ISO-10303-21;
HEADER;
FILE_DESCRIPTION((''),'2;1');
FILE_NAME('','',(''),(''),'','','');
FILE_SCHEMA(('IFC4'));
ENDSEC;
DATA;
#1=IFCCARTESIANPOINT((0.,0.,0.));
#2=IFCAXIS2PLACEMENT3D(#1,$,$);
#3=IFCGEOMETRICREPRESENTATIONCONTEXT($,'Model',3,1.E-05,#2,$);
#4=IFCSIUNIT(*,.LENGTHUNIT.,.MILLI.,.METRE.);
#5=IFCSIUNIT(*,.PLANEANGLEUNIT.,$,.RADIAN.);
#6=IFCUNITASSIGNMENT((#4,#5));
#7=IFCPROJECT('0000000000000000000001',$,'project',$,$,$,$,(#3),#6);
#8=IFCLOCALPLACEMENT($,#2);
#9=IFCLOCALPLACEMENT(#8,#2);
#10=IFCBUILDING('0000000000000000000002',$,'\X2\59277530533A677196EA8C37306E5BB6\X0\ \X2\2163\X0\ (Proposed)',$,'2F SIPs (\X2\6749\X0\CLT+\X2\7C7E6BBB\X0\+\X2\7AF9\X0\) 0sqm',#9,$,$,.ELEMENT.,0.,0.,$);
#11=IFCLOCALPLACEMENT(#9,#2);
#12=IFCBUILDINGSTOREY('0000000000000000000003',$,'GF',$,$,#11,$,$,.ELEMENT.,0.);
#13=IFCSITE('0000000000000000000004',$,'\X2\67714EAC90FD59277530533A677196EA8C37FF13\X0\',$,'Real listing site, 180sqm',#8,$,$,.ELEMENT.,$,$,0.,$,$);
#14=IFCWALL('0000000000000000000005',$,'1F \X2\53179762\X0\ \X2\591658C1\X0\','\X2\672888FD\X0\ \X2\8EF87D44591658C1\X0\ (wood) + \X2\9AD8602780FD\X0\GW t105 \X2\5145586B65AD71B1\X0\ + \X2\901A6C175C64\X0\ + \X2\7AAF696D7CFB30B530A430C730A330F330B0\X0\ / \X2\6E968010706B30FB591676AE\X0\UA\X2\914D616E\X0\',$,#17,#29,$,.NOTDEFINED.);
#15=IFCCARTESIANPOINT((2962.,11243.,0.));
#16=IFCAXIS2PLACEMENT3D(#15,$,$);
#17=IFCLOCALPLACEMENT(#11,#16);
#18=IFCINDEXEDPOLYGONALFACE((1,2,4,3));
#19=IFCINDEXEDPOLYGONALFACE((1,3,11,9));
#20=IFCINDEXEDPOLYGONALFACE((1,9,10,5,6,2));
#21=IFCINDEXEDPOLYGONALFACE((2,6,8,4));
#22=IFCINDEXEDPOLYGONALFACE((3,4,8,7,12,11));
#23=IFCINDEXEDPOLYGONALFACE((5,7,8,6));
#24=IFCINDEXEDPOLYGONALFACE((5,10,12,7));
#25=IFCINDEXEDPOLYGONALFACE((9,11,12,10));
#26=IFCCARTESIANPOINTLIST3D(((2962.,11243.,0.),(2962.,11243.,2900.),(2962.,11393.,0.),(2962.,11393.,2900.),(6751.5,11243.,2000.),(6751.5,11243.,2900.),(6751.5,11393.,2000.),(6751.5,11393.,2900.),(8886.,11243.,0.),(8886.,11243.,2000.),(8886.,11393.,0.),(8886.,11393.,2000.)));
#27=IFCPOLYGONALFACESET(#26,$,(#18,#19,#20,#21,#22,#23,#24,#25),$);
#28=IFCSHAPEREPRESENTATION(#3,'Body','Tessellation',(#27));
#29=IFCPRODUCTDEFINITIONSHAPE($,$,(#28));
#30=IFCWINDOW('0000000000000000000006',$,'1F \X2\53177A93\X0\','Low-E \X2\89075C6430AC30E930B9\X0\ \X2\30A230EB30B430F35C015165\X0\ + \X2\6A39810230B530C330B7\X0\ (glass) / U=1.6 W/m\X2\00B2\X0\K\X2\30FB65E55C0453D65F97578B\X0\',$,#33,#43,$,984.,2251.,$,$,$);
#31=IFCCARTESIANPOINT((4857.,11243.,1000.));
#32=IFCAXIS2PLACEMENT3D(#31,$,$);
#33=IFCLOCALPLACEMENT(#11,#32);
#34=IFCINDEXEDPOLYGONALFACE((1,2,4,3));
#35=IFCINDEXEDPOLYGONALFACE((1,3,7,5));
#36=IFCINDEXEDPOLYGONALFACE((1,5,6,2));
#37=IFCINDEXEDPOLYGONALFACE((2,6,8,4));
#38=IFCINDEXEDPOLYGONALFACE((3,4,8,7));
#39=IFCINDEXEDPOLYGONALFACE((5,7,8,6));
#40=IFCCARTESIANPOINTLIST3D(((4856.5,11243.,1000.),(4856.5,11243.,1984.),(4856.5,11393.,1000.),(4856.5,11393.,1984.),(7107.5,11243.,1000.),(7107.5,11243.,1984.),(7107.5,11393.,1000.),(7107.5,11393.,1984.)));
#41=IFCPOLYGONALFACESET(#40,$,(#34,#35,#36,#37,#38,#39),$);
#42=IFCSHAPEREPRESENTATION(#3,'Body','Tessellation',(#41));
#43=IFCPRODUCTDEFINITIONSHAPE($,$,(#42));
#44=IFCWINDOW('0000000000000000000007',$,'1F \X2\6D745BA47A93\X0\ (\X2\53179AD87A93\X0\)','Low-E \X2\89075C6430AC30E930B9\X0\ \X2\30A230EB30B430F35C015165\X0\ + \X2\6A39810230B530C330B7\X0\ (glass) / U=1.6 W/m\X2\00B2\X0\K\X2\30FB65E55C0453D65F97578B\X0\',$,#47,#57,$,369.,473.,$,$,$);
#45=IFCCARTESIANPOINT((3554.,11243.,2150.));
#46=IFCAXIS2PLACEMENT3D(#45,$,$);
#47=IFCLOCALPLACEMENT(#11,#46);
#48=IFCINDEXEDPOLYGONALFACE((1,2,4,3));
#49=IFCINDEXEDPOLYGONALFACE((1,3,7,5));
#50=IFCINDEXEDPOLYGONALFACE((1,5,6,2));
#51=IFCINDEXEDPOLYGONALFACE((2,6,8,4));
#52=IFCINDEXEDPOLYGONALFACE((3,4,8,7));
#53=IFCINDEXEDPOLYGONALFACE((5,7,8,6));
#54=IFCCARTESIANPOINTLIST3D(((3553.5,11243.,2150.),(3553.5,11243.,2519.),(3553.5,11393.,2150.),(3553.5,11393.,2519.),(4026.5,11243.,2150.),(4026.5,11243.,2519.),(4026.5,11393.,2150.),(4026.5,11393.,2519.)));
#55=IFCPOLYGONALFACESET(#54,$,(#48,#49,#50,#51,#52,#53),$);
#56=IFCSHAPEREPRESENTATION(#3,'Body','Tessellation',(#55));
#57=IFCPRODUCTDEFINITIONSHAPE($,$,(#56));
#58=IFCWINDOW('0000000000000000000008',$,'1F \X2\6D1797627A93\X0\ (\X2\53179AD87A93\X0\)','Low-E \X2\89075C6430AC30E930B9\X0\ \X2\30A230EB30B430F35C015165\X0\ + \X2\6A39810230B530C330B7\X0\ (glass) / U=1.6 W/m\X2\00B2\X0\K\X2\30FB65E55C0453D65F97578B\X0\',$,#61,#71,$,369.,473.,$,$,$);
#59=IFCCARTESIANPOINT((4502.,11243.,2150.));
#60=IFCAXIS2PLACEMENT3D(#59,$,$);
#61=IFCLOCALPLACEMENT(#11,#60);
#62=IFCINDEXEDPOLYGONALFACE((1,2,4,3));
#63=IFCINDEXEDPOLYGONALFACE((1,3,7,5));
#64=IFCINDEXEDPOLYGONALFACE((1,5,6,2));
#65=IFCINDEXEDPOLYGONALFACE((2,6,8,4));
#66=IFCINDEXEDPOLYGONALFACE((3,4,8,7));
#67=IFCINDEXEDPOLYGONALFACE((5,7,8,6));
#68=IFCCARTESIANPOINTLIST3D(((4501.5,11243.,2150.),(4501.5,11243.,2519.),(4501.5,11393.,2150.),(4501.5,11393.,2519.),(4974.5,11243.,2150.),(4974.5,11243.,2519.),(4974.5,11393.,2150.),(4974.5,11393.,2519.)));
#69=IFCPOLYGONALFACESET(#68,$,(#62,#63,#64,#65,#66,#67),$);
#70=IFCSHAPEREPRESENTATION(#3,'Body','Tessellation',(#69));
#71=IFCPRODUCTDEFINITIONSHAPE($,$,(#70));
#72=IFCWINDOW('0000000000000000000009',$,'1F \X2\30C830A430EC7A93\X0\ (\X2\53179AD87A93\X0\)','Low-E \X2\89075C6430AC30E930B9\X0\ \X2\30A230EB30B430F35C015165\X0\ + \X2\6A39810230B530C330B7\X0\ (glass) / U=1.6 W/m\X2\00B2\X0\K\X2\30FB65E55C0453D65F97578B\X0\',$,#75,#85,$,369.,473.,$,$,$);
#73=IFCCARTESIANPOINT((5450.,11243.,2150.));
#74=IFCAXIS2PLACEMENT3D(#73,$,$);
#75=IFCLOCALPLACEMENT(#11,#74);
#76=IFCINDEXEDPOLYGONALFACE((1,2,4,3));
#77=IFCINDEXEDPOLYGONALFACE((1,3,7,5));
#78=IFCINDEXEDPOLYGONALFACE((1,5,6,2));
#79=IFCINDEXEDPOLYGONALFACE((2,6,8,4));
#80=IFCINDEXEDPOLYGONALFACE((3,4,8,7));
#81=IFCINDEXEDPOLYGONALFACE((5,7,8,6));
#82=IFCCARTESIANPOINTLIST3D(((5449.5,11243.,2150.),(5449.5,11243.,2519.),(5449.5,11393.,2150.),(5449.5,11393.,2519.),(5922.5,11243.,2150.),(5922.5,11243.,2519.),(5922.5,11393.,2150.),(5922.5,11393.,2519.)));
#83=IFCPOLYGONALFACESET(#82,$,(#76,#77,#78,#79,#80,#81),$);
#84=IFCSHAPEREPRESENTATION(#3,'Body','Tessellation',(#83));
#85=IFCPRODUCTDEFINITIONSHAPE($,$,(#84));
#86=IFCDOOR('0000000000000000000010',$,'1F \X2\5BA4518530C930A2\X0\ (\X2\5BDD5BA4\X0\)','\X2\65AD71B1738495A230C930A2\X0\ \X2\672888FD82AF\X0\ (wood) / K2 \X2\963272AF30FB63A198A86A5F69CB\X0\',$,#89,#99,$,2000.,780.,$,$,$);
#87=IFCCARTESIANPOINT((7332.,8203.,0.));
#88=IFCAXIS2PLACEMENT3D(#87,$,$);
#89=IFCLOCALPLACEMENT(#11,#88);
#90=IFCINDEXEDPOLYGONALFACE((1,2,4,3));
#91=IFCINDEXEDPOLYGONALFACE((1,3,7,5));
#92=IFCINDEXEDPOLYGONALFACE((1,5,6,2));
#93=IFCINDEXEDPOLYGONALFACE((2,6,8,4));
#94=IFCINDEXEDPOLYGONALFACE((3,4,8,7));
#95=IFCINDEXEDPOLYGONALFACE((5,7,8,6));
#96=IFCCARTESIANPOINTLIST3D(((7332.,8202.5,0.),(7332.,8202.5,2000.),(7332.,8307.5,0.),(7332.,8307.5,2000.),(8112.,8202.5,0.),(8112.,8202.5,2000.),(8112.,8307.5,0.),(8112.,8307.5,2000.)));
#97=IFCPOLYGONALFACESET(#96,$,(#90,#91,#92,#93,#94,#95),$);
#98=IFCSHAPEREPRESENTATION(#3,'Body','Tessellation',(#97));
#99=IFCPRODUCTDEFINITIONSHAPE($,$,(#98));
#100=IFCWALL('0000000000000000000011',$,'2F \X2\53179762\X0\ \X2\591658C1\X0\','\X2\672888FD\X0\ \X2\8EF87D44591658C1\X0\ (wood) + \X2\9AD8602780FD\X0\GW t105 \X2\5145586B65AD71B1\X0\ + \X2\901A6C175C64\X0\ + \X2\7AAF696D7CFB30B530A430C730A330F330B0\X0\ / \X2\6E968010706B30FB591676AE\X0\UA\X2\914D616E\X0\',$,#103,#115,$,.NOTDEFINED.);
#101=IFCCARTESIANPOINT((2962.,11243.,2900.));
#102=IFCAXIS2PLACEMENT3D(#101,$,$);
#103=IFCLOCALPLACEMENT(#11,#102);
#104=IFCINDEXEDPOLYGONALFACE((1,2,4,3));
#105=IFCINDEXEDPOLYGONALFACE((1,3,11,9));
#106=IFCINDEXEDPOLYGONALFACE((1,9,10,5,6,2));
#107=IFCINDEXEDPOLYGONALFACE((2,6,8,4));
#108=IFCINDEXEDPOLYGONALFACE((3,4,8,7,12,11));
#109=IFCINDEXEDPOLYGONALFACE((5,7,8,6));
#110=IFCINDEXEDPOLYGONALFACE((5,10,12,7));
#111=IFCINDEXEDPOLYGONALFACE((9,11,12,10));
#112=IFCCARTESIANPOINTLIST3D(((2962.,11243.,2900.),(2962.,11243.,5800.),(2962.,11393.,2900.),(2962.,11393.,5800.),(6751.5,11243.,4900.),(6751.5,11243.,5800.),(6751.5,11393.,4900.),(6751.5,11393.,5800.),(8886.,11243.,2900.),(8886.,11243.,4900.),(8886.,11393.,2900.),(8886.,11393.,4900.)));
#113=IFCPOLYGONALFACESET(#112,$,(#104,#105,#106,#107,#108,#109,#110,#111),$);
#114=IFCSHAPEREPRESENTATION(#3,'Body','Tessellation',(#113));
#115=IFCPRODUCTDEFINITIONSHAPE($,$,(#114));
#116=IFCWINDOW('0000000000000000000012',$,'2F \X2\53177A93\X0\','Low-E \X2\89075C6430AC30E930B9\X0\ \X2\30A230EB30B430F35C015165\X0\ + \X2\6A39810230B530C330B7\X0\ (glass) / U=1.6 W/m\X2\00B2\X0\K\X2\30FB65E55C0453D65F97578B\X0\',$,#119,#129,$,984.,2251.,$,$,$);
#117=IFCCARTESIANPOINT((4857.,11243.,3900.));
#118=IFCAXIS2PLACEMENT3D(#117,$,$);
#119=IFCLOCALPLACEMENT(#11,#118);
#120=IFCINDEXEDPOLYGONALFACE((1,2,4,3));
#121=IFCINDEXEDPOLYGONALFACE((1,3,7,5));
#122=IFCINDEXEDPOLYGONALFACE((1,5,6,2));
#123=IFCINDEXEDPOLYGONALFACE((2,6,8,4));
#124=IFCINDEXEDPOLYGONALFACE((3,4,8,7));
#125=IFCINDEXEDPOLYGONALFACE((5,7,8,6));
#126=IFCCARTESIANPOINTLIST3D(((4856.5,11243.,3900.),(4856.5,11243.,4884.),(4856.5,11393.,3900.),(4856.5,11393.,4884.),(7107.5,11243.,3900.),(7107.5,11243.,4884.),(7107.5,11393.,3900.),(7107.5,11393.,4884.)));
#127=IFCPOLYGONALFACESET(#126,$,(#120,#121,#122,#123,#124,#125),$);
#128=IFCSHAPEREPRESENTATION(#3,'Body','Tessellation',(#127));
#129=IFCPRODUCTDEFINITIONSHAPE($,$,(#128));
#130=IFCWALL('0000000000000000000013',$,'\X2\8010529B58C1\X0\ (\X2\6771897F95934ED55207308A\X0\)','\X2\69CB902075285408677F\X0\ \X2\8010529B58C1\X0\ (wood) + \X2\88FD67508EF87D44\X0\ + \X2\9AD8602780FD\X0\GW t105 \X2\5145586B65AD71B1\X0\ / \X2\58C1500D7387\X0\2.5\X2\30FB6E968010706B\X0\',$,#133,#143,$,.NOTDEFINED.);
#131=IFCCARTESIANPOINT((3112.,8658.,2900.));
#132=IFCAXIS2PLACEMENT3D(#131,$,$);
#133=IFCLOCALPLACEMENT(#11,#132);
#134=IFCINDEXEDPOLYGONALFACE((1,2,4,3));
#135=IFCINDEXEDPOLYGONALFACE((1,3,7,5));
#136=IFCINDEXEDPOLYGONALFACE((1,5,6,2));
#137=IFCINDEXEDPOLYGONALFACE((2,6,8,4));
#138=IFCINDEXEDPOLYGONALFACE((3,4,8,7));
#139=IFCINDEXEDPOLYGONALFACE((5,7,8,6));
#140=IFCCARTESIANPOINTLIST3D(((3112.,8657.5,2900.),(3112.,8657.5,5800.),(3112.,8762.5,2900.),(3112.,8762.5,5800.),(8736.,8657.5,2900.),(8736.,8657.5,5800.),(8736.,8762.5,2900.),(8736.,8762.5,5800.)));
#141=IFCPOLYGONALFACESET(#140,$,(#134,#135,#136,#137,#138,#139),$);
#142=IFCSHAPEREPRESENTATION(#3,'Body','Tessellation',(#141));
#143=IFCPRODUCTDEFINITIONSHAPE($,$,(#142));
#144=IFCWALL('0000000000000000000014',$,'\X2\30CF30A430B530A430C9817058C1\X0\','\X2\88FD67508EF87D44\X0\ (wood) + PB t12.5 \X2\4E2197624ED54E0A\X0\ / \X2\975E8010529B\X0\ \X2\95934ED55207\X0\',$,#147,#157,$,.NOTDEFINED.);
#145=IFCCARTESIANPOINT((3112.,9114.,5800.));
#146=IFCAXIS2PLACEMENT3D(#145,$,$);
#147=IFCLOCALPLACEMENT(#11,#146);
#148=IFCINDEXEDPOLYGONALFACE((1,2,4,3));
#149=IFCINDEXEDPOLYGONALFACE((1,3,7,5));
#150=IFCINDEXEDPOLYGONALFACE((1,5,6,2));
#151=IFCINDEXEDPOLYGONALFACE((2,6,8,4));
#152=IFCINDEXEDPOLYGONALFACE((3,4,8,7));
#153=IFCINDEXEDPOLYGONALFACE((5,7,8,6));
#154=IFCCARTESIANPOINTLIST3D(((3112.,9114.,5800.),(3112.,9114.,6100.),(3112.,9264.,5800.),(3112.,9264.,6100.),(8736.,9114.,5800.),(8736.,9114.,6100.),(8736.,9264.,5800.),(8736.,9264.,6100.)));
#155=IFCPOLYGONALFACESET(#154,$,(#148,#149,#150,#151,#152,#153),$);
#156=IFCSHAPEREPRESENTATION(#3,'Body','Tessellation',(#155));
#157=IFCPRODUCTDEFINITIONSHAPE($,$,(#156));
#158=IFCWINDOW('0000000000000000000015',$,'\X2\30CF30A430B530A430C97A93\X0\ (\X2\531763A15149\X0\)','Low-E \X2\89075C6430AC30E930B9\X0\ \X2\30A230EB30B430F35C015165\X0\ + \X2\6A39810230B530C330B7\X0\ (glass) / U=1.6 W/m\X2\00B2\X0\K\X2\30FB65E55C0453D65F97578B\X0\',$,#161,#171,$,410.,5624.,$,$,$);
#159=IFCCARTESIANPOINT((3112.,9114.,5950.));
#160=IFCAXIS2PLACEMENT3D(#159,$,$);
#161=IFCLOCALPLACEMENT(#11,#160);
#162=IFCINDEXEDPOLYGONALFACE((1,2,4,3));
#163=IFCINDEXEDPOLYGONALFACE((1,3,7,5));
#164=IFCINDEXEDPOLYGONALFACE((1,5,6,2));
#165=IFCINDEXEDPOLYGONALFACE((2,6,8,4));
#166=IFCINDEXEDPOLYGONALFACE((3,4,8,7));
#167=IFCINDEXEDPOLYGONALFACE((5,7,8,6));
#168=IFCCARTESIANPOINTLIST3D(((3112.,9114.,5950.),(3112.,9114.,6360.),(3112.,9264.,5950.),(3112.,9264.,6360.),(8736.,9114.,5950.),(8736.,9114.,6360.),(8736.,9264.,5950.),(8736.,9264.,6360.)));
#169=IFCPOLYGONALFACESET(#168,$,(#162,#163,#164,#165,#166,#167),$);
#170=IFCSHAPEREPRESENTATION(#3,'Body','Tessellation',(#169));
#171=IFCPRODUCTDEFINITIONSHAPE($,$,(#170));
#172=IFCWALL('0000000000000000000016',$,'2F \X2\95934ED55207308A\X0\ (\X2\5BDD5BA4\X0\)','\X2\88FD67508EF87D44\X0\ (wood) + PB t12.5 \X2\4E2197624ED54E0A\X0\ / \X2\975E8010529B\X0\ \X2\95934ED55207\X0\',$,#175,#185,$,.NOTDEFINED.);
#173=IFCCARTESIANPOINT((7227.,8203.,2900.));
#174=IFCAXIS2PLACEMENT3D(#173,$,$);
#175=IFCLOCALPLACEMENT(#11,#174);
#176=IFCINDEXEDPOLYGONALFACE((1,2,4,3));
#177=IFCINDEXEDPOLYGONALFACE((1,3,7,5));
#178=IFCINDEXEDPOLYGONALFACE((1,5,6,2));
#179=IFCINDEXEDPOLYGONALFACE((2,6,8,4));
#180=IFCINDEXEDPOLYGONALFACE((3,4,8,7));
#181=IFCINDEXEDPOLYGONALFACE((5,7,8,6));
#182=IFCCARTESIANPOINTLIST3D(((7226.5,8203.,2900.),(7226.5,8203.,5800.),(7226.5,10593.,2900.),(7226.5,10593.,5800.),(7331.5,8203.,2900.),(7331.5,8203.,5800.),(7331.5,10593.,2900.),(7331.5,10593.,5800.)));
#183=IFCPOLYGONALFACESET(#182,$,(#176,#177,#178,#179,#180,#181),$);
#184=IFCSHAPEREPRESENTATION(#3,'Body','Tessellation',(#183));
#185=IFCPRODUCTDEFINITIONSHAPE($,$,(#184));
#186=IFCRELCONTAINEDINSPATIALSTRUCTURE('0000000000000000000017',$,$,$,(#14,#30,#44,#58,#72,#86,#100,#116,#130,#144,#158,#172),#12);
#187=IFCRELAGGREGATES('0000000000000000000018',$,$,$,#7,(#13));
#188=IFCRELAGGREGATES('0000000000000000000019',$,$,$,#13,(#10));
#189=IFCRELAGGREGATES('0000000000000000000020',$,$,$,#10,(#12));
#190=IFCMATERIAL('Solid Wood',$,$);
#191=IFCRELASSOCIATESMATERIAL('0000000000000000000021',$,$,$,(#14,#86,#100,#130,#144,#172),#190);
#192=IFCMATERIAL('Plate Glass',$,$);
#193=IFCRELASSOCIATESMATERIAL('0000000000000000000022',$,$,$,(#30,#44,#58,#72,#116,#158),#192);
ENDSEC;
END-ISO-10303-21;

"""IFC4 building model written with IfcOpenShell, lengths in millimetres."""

from ifc_helpers import new_model, si_unit, frame, frame_2d, origin, place, context, project, spatial, rectangle, extrude, material, element, fill, save


model = new_model("IFC4")

# Units and contexts
model_context = context("Model", 3, precision=1e-05, world=origin())
ifc_project = project(units=[si_unit("LENGTHUNIT", "METRE", prefix="MILLI"), si_unit("PLANEANGLEUNIT", "RADIAN")], contexts=[model_context])

# Site, building, storey
site_placement = place(None, origin())
site = spatial("IfcSite", under=ifc_project, at=site_placement, Name="東京都大田区東雪谷３", ObjectType="Real listing site, 180sqm", CompositionType="ELEMENT", RefElevation=0.0)
building_placement = place(site_placement, origin())
building = spatial("IfcBuilding", under=site, at=building_placement, Name="大田区東雪谷の家 Ⅳ (Proposed)", ObjectType="2F SIPs (杉CLT+籾殻+竹) 0sqm", CompositionType="ELEMENT", ElevationOfRefHeight=0.0, ElevationOfTerrain=0.0)
storey_placement = place(building_placement, origin())
storey = spatial("IfcBuildingStorey", under=building, at=storey_placement, Name="GF", CompositionType="ELEMENT", Elevation=0.0)

# Wall, openings, windows
ifc_material_1 = material(Name="Solid Wood")
wall_1_placement = place(storey_placement, frame((2962.0, 11243.0, 0.0)))
wall_1 = element("IfcWall", 1, at=wall_1_placement, inside=storey, material=ifc_material_1, Name="1F 北面 外壁", Description="木製 軸組外壁 (wood) + 高性能GW t105 充填断熱 + 通気層 + 窯業系サイディング / 準耐火・外皮UA配慮", PredefinedType="NOTDEFINED", context=model_context, shape_type="SweptSolid", body=[
    extrude(rectangle(XDim=5924.0, YDim=150.0, at=frame_2d((2962.0, 75.0))), frame((2962.0, 11243.0, 0.0)), (0.0, 0.0, 1.0), 2900.0),
])
opening_1_placement = place(storey_placement, frame((4857.0, 11243.0, 1000.0)))
opening_1 = element("IfcOpeningElement", 2, at=opening_1_placement, cuts=wall_1, PredefinedType="NOTDEFINED", context=model_context, shape_type="SweptSolid", body=[
    extrude(rectangle(XDim=2251.0, YDim=150.0, at=frame_2d((1125.0, 75.0))), frame((4857.0, 11243.0, 1000.0)), (0.0, 0.0, 1.0), 984.0),
])
opening_2_placement = place(storey_placement, frame((3554.0, 11243.0, 2150.0)))
opening_2 = element("IfcOpeningElement", 3, at=opening_2_placement, cuts=wall_1, PredefinedType="NOTDEFINED", context=model_context, shape_type="SweptSolid", body=[
    extrude(rectangle(XDim=473.0, YDim=150.0, at=frame_2d((236.0, 75.0))), frame((3554.0, 11243.0, 2150.0)), (0.0, 0.0, 1.0), 369.0),
])
opening_3_placement = place(storey_placement, frame((4502.0, 11243.0, 2150.0)))
opening_3 = element("IfcOpeningElement", 4, at=opening_3_placement, cuts=wall_1, PredefinedType="NOTDEFINED", context=model_context, shape_type="SweptSolid", body=[
    extrude(rectangle(XDim=473.0, YDim=150.0, at=frame_2d((236.0, 75.0))), frame((4502.0, 11243.0, 2150.0)), (0.0, 0.0, 1.0), 369.0),
])
opening_4_placement = place(storey_placement, frame((5450.0, 11243.0, 2150.0)))
opening_4 = element("IfcOpeningElement", 5, at=opening_4_placement, cuts=wall_1, PredefinedType="NOTDEFINED", context=model_context, shape_type="SweptSolid", body=[
    extrude(rectangle(XDim=473.0, YDim=150.0, at=frame_2d((236.0, 75.0))), frame((5450.0, 11243.0, 2150.0)), (0.0, 0.0, 1.0), 369.0),
])
ifc_material_2 = material(Name="Plate Glass")
window_1_placement = place(storey_placement, frame((4857.0, 11243.0, 1000.0)))
window_1 = element("IfcWindow", 6, at=window_1_placement, inside=storey, material=ifc_material_2, Name="1F 北窓", Description="Low-E 複層ガラス アルゴン封入 + 樹脂サッシ (glass) / U=1.6 W/m²K・日射取得型", OverallHeight=984.0, OverallWidth=2251.0, context=model_context, shape_type="SweptSolid", body=[
    extrude(rectangle(XDim=2251.0, YDim=150.0, at=frame_2d((1125.0, 75.0))), frame((4857.0, 11243.0, 1000.0)), (0.0, 0.0, 1.0), 984.0),
])
fill(opening_1, window_1)
window_2_placement = place(storey_placement, frame((3554.0, 11243.0, 2150.0)))
window_2 = element("IfcWindow", 7, at=window_2_placement, inside=storey, material=ifc_material_2, Name="1F 浴室窓 (北高窓)", Description="Low-E 複層ガラス アルゴン封入 + 樹脂サッシ (glass) / U=1.6 W/m²K・日射取得型", OverallHeight=369.0, OverallWidth=473.0, context=model_context, shape_type="SweptSolid", body=[
    extrude(rectangle(XDim=473.0, YDim=150.0, at=frame_2d((236.0, 75.0))), frame((3554.0, 11243.0, 2150.0)), (0.0, 0.0, 1.0), 369.0),
])
fill(opening_2, window_2)
window_3_placement = place(storey_placement, frame((4502.0, 11243.0, 2150.0)))
window_3 = element("IfcWindow", 8, at=window_3_placement, inside=storey, material=ifc_material_2, Name="1F 洗面窓 (北高窓)", Description="Low-E 複層ガラス アルゴン封入 + 樹脂サッシ (glass) / U=1.6 W/m²K・日射取得型", OverallHeight=369.0, OverallWidth=473.0, context=model_context, shape_type="SweptSolid", body=[
    extrude(rectangle(XDim=473.0, YDim=150.0, at=frame_2d((236.0, 75.0))), frame((4502.0, 11243.0, 2150.0)), (0.0, 0.0, 1.0), 369.0),
])
fill(opening_3, window_3)
window_4_placement = place(storey_placement, frame((5450.0, 11243.0, 2150.0)))
window_4 = element("IfcWindow", 9, at=window_4_placement, inside=storey, material=ifc_material_2, Name="1F トイレ窓 (北高窓)", Description="Low-E 複層ガラス アルゴン封入 + 樹脂サッシ (glass) / U=1.6 W/m²K・日射取得型", OverallHeight=369.0, OverallWidth=473.0, context=model_context, shape_type="SweptSolid", body=[
    extrude(rectangle(XDim=473.0, YDim=150.0, at=frame_2d((236.0, 75.0))), frame((5450.0, 11243.0, 2150.0)), (0.0, 0.0, 1.0), 369.0),
])
fill(opening_4, window_4)

# Door
door_1_placement = place(storey_placement, frame((7332.0, 8203.0, 0.0)))
element("IfcDoor", 10, at=door_1_placement, inside=storey, material=ifc_material_1, Name="1F 室内ドア (寝室)", Description="断熱玄関ドア 木製芯 (wood) / K2 防犯・採風機構", OverallHeight=2000.0, OverallWidth=780.0, context=model_context, shape_type="SweptSolid", body=[
    extrude(rectangle(XDim=780.0, YDim=105.0, at=frame_2d((390.0, 52.0))), frame((7332.0, 8203.0, 0.0)), (0.0, 0.0, 1.0), 2000.0),
])

# Wall, opening, window
wall_2_placement = place(storey_placement, frame((2962.0, 11243.0, 2900.0)))
wall_2 = element("IfcWall", 11, at=wall_2_placement, inside=storey, material=ifc_material_1, Name="2F 北面 外壁", Description="木製 軸組外壁 (wood) + 高性能GW t105 充填断熱 + 通気層 + 窯業系サイディング / 準耐火・外皮UA配慮", PredefinedType="NOTDEFINED", context=model_context, shape_type="SweptSolid", body=[
    extrude(rectangle(XDim=5924.0, YDim=150.0, at=frame_2d((2962.0, 75.0))), frame((2962.0, 11243.0, 2900.0)), (0.0, 0.0, 1.0), 2900.0),
])
opening_5_placement = place(storey_placement, frame((4857.0, 11243.0, 3900.0)))
opening_5 = element("IfcOpeningElement", 12, at=opening_5_placement, cuts=wall_2, PredefinedType="NOTDEFINED", context=model_context, shape_type="SweptSolid", body=[
    extrude(rectangle(XDim=2251.0, YDim=150.0, at=frame_2d((1125.0, 75.0))), frame((4857.0, 11243.0, 3900.0)), (0.0, 0.0, 1.0), 984.0),
])
window_5_placement = place(storey_placement, frame((4857.0, 11243.0, 3900.0)))
window_5 = element("IfcWindow", 13, at=window_5_placement, inside=storey, material=ifc_material_2, Name="2F 北窓", Description="Low-E 複層ガラス アルゴン封入 + 樹脂サッシ (glass) / U=1.6 W/m²K・日射取得型", OverallHeight=984.0, OverallWidth=2251.0, context=model_context, shape_type="SweptSolid", body=[
    extrude(rectangle(XDim=2251.0, YDim=150.0, at=frame_2d((1125.0, 75.0))), frame((4857.0, 11243.0, 3900.0)), (0.0, 0.0, 1.0), 984.0),
])
fill(opening_5, window_5)

# Wall
wall_3_placement = place(storey_placement, frame((3112.0, 8658.0, 2900.0)))
element("IfcWall", 14, at=wall_3_placement, inside=storey, material=ifc_material_1, Name="耐力壁 (東西間仕切り)", Description="構造用合板 耐力壁 (wood) + 製材軸組 + 高性能GW t105 充填断熱 / 壁倍率2.5・準耐火", PredefinedType="NOTDEFINED", context=model_context, shape_type="SweptSolid", body=[
    extrude(rectangle(XDim=5624.0, YDim=105.0, at=frame_2d((2812.0, 52.0))), frame((3112.0, 8658.0, 2900.0)), (0.0, 0.0, 1.0), 2900.0),
])

# Wall, opening, window
wall_4_placement = place(storey_placement, frame((3112.0, 9114.0, 5800.0)))
wall_4 = element("IfcWall", 15, at=wall_4_placement, inside=storey, material=ifc_material_1, Name="ハイサイド腰壁", Description="製材軸組 (wood) + PB t12.5 両面仕上 / 非耐力 間仕切", PredefinedType="NOTDEFINED", context=model_context, shape_type="SweptSolid", body=[
    extrude(rectangle(XDim=5624.0, YDim=150.0, at=frame_2d((2812.0, 75.0))), frame((3112.0, 9114.0, 5800.0)), (0.0, 0.0, 1.0), 700.0),
])
opening_6_placement = place(storey_placement, frame((3112.0, 9114.0, 5950.0)))
opening_6 = element("IfcOpeningElement", 16, at=opening_6_placement, cuts=wall_4, PredefinedType="NOTDEFINED", context=model_context, shape_type="SweptSolid", body=[
    extrude(rectangle(XDim=5624.0, YDim=150.0, at=frame_2d((2812.0, 75.0))), frame((3112.0, 9114.0, 5950.0)), (0.0, 0.0, 1.0), 410.0),
])
window_6_placement = place(storey_placement, frame((3112.0, 9114.0, 5950.0)))
window_6 = element("IfcWindow", 17, at=window_6_placement, inside=storey, material=ifc_material_2, Name="ハイサイド窓 (北採光)", Description="Low-E 複層ガラス アルゴン封入 + 樹脂サッシ (glass) / U=1.6 W/m²K・日射取得型", OverallHeight=410.0, OverallWidth=5624.0, context=model_context, shape_type="SweptSolid", body=[
    extrude(rectangle(XDim=5624.0, YDim=150.0, at=frame_2d((2812.0, 75.0))), frame((3112.0, 9114.0, 5950.0)), (0.0, 0.0, 1.0), 410.0),
])
fill(opening_6, window_6)

# Wall
wall_5_placement = place(storey_placement, frame((7227.0, 8203.0, 2900.0)))
element("IfcWall", 18, at=wall_5_placement, inside=storey, material=ifc_material_1, Name="2F 間仕切り (寝室)", Description="製材軸組 (wood) + PB t12.5 両面仕上 / 非耐力 間仕切", PredefinedType="NOTDEFINED", context=model_context, shape_type="SweptSolid", body=[
    extrude(rectangle(XDim=105.0, YDim=2390.0, at=frame_2d((52.0, 1195.0))), frame((7227.0, 8203.0, 2900.0)), (0.0, 0.0, 1.0), 2900.0),
])

save(model, "model.ifc")
